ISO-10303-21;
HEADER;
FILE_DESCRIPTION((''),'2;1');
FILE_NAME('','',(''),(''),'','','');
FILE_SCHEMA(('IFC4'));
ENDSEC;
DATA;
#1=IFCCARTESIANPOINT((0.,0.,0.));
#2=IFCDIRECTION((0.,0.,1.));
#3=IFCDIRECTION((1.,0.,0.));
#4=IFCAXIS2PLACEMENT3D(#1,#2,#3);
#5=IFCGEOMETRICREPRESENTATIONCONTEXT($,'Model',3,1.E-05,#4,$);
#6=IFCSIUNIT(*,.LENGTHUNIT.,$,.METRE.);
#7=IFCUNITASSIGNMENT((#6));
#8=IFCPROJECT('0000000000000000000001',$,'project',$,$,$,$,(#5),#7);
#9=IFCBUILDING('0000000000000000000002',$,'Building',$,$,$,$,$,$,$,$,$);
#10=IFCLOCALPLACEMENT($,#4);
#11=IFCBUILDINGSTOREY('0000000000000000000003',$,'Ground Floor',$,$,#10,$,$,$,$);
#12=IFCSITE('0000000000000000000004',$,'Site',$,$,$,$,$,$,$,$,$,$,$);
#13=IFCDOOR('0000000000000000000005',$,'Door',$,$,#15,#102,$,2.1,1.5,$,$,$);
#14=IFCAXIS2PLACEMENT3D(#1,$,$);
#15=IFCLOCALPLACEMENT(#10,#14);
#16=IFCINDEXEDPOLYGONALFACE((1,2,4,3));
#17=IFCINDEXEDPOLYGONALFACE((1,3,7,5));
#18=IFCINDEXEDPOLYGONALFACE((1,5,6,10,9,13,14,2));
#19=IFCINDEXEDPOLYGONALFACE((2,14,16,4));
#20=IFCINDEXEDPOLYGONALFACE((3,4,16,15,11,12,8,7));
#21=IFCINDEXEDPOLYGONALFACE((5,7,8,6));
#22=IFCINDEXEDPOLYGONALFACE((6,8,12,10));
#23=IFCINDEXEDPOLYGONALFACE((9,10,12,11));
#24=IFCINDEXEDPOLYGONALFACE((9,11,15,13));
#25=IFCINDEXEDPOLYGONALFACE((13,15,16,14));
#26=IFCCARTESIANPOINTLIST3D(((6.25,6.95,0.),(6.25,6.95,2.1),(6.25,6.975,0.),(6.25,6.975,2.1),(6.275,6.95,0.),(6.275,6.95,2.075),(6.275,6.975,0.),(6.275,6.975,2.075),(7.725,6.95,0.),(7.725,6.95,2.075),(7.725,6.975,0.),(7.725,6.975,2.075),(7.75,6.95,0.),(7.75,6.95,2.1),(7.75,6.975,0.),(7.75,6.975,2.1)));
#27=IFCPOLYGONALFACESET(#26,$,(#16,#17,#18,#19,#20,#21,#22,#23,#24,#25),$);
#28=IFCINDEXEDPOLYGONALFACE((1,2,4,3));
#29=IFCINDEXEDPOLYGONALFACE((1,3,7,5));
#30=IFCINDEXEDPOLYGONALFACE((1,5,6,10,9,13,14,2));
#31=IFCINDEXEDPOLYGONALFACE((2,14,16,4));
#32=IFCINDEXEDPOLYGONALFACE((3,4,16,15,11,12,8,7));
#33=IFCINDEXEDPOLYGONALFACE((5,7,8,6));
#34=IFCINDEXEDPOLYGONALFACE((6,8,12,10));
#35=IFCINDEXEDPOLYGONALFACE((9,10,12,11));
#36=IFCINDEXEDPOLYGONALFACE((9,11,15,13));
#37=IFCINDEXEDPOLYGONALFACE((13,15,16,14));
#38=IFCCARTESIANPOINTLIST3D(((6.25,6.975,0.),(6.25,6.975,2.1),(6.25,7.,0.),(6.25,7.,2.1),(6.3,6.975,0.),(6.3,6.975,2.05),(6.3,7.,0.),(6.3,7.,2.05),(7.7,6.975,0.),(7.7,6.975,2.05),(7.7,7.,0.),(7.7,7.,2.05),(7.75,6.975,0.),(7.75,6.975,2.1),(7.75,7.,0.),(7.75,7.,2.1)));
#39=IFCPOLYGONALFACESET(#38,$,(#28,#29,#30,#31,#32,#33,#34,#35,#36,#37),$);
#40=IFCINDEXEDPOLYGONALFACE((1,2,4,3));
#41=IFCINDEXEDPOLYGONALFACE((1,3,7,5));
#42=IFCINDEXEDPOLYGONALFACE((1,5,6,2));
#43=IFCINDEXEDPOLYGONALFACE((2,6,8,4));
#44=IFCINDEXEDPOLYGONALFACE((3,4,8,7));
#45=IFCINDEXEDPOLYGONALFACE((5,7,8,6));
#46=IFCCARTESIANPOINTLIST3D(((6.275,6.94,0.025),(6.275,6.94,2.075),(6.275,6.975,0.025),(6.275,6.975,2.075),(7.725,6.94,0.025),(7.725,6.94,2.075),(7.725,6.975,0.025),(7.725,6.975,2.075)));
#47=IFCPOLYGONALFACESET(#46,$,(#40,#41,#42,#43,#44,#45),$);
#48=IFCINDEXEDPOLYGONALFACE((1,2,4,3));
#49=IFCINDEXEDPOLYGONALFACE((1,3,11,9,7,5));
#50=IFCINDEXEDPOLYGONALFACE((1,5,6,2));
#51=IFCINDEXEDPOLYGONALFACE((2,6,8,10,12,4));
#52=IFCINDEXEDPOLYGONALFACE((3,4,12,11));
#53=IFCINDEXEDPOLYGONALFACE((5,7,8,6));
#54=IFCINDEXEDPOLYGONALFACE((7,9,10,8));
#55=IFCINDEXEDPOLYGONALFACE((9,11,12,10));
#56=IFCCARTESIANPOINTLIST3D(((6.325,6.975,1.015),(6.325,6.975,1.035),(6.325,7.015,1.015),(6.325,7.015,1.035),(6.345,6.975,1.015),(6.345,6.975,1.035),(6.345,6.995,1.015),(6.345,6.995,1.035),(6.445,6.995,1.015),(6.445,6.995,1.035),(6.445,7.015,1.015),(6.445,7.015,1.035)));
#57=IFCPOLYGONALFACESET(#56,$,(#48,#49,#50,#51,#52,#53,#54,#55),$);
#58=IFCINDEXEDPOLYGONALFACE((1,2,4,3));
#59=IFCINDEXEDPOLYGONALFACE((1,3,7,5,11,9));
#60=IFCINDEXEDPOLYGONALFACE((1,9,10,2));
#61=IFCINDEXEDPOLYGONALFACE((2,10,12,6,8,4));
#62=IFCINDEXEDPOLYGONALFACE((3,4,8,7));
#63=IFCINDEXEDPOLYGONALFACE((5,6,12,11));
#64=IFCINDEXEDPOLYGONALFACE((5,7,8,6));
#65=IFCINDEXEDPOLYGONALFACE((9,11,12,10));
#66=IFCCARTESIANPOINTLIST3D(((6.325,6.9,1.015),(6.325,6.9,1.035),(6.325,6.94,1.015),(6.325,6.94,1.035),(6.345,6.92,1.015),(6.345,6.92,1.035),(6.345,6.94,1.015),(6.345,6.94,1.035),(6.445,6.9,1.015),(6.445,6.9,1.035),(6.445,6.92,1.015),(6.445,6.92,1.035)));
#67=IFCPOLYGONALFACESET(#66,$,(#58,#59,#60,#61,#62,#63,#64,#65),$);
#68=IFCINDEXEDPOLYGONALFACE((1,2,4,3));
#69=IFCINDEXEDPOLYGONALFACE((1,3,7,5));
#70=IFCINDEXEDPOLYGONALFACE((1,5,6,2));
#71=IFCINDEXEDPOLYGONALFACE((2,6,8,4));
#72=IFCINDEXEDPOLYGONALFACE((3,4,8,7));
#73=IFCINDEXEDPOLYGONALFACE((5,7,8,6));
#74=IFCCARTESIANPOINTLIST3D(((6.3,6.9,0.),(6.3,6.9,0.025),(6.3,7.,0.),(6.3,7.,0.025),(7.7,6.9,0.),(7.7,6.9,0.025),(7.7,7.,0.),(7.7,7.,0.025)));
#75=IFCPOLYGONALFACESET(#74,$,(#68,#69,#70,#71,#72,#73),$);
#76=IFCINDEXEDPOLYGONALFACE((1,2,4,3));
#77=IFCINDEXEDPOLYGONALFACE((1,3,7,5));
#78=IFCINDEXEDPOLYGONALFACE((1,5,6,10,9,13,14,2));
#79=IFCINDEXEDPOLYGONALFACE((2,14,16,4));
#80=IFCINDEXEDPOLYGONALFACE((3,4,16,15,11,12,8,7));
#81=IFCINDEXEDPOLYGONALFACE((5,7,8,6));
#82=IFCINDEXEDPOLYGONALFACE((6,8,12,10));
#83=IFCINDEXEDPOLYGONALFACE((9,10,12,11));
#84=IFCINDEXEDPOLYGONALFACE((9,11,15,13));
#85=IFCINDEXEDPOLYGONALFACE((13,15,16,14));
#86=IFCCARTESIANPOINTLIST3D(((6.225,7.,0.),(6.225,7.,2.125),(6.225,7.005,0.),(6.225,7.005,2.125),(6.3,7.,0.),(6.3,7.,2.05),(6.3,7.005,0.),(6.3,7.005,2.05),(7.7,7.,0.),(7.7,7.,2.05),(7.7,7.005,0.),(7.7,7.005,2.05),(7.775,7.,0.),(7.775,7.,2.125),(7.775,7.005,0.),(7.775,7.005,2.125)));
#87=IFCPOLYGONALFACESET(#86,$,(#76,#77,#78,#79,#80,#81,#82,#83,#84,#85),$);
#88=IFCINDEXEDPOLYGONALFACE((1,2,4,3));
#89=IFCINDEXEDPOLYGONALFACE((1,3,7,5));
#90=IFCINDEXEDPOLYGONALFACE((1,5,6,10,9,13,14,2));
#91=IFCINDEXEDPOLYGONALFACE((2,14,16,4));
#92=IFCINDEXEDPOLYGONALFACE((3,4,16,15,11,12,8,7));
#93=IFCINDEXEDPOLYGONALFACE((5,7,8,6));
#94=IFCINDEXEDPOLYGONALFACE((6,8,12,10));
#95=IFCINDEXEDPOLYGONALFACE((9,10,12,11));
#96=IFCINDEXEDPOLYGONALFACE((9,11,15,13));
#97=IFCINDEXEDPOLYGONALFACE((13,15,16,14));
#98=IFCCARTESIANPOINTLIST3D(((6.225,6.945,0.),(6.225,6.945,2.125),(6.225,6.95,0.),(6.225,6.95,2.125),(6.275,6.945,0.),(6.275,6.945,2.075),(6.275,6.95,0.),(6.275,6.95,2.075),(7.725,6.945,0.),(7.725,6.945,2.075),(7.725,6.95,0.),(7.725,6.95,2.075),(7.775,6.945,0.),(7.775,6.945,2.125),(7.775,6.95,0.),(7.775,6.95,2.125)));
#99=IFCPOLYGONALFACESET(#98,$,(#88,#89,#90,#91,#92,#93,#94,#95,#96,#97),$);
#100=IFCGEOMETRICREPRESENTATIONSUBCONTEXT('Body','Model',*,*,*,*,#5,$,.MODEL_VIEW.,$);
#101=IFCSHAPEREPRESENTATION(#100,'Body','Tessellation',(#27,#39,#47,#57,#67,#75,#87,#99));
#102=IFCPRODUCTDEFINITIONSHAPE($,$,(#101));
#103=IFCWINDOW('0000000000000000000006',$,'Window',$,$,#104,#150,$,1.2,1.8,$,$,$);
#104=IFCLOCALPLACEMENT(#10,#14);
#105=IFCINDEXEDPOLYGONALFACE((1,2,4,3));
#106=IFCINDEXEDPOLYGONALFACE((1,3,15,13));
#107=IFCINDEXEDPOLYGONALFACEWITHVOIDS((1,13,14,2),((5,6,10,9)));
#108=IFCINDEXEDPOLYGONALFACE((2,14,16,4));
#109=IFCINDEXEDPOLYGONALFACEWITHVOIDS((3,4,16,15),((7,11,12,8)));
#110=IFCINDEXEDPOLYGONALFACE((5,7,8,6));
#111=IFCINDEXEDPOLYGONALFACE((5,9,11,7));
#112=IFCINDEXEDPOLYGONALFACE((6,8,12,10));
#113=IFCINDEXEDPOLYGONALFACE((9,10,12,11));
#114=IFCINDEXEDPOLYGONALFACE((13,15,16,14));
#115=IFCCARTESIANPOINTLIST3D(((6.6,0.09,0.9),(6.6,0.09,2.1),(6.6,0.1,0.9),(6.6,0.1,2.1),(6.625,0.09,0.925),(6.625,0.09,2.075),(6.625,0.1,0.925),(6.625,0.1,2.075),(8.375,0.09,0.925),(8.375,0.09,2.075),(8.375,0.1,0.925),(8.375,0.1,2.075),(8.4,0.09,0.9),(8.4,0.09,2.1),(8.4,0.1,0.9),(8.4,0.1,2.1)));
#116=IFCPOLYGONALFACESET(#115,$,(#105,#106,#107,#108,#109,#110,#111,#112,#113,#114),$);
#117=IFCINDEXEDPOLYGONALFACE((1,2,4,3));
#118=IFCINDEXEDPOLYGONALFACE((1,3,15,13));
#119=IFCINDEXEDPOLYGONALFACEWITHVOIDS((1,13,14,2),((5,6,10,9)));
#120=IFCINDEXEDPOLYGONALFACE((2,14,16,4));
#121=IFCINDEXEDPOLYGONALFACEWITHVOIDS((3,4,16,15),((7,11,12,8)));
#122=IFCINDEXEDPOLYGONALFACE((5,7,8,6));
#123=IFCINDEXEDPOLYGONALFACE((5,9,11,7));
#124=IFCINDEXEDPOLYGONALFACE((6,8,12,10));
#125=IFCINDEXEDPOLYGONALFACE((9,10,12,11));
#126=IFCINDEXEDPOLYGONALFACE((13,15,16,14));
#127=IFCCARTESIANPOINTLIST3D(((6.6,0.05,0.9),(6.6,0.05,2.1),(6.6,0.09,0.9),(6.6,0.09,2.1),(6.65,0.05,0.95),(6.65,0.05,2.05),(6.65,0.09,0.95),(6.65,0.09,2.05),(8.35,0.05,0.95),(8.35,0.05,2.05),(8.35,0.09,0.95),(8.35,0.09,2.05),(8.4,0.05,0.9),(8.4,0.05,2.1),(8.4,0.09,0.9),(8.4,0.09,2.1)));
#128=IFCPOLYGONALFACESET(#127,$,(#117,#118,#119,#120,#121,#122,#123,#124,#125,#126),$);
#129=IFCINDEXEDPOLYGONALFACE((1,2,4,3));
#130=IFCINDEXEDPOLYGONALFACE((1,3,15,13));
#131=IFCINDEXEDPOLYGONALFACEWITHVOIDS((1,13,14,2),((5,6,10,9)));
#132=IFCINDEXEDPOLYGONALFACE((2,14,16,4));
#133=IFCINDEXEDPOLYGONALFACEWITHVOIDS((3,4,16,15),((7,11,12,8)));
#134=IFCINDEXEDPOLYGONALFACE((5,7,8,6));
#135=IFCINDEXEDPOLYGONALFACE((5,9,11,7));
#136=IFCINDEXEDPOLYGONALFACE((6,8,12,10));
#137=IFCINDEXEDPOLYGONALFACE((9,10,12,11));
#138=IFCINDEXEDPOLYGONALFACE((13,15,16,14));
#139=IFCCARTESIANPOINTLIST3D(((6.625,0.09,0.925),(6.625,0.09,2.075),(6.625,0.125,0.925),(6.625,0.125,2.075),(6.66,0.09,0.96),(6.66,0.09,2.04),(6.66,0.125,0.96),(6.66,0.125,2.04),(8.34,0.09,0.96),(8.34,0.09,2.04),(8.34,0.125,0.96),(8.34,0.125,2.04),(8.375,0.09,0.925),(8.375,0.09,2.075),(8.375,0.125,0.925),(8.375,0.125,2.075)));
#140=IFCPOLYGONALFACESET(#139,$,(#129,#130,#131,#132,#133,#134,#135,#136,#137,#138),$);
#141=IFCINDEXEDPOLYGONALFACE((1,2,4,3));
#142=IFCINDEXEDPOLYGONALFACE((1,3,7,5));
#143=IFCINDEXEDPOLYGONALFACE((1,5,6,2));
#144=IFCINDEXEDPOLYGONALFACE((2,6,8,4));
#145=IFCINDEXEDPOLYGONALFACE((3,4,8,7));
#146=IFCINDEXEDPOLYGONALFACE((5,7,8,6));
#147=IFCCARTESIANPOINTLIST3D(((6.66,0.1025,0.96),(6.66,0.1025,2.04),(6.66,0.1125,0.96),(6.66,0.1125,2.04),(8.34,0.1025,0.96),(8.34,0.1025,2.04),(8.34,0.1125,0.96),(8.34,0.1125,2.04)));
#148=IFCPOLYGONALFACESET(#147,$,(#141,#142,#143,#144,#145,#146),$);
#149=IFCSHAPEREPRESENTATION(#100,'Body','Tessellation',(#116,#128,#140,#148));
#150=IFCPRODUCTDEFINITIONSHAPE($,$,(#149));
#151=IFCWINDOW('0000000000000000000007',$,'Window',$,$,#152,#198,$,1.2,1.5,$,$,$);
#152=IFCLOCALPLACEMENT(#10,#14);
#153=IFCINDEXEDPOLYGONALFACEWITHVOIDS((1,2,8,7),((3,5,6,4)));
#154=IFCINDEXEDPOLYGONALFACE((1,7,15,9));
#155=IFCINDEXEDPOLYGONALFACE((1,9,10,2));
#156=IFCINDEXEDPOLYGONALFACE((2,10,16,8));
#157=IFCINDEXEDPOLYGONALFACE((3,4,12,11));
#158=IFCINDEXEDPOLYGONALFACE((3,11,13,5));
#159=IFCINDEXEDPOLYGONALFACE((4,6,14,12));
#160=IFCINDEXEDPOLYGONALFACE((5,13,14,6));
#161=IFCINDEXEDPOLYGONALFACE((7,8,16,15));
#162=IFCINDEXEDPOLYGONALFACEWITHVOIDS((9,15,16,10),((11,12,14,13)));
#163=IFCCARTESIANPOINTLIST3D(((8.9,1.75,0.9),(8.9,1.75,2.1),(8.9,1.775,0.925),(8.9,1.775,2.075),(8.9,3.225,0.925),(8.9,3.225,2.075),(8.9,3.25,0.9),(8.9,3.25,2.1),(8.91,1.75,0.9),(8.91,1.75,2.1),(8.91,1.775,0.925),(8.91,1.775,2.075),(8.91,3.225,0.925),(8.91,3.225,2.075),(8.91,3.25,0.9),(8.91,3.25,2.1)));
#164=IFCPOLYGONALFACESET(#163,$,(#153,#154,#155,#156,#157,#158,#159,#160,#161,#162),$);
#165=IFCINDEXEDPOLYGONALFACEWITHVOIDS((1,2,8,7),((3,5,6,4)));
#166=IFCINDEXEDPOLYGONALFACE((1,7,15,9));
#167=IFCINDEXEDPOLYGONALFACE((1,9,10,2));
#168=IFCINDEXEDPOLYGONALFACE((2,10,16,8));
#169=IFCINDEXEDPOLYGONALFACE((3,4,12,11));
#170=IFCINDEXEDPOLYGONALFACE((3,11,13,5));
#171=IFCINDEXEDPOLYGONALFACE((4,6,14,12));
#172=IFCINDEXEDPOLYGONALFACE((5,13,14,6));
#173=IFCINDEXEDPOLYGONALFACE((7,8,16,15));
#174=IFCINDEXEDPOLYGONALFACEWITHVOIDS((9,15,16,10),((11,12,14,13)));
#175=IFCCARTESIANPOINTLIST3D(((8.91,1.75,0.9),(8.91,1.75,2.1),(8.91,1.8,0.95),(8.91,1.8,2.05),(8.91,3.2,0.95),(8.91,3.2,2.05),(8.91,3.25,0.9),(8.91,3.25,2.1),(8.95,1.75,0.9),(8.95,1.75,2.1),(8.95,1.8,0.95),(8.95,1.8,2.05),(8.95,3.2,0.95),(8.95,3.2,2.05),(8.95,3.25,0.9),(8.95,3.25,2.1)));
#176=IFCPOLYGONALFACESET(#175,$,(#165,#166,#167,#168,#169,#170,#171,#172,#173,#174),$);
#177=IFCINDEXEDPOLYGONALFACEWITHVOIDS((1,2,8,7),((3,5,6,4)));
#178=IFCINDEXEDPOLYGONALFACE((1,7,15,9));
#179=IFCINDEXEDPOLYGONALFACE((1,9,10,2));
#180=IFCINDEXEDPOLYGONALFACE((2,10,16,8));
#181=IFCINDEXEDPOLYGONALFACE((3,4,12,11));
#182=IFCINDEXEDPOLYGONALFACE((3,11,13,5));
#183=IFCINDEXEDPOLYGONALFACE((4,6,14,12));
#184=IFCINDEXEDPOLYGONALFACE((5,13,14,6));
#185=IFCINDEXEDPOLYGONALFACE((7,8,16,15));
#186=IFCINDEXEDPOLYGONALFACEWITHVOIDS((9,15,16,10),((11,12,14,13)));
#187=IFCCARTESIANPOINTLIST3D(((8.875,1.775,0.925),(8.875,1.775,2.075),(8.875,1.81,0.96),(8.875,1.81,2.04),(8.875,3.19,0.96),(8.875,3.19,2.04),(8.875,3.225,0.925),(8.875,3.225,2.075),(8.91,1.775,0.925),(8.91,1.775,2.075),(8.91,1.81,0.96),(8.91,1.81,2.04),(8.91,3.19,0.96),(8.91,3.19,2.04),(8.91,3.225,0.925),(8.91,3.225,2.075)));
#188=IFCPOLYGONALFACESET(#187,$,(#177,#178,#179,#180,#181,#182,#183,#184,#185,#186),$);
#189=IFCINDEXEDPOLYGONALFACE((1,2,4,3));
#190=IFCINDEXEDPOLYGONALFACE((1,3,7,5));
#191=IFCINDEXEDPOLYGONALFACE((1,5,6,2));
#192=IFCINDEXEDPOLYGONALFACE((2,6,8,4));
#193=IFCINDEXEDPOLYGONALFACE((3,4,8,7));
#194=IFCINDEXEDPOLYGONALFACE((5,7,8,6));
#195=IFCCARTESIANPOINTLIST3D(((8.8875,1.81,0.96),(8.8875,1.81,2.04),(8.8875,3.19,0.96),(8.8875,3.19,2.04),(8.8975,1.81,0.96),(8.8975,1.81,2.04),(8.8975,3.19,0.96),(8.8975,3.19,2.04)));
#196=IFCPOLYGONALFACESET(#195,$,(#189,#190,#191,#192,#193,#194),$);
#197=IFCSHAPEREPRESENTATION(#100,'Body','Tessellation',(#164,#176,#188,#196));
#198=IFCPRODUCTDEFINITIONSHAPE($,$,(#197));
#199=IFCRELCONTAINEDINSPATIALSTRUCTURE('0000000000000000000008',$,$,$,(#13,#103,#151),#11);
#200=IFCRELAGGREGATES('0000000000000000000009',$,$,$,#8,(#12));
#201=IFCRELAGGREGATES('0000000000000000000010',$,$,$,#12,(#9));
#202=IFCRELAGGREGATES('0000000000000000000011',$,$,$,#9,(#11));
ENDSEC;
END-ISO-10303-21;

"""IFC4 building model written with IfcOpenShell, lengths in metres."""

from ifc_helpers import new_model, si_unit, frame, origin_with_axes, place, context, subcontext, project, spatial, line, indexed_curve, outline, extrude, element, save


model = new_model("IFC4")

# Units and contexts
model_context = context("Model", 3, precision=1e-05, world=origin_with_axes())
body_context = subcontext(model_context, "Body", "Model", "MODEL_VIEW")
ifc_project = project(units=[si_unit("LENGTHUNIT", "METRE")], contexts=[model_context])

# Site, building, storey
site = spatial("IfcSite", under=ifc_project, Name="Site")
building = spatial("IfcBuilding", under=site, Name="Building")
storey_placement = place(None, origin_with_axes())
storey = spatial("IfcBuildingStorey", under=building, at=storey_placement, Name="Ground Floor")

# Door
door_1_placement = place(storey_placement, frame((7.75, 7.0, 0.0), z_axis=(0.0, 0.0, 1.0), x_axis=(-1.0, 0.0, 0.0)))
element("IfcDoor", 1, at=door_1_placement, inside=storey, Name="Door", OverallHeight=2.1, OverallWidth=1.5, context=body_context, shape_type="SweptSolid", body=[
    extrude(outline(indexed_curve([(0.0, 0.0), (0.0, 2.1), (1.5, 2.1), (1.5, 0.0), (1.475, 0.0), (1.475, 2.075), (0.025, 2.075), (0.025, 0.0)], segments=[line(1, 2, 3, 4, 5, 6, 7, 8, 1)])), frame((0.0, 0.025, 0.0), z_axis=(0.0, -1.0, 0.0), x_axis=(1.0, 0.0, 0.0)), (0.0, 0.0, -1.0), 0.025),
    extrude(outline(indexed_curve([(0.0, 0.0), (0.0, 2.1), (1.5, 2.1), (1.5, 0.0), (1.45, 0.0), (1.45, 2.05), (0.05, 2.05), (0.05, 0.0)], segments=[line(1, 2, 3, 4, 5, 6, 7, 8, 1)])), frame((0.0, 0.0, 0.0), z_axis=(0.0, -1.0, 0.0), x_axis=(1.0, 0.0, 0.0)), (0.0, 0.0, -1.0), 0.025),
    extrude(outline(indexed_curve([(0.0, 0.0), (1.45, 0.0), (1.45, 0.035), (0.0, 0.035)], segments=[line(1, 2, 3, 4, 1)])), frame((0.025, 0.025, 0.025), z_axis=(0.0, 0.0, 1.0), x_axis=(1.0, 0.0, 0.0)), (0.0, 0.0, 1.0), 2.05),
    extrude(outline(indexed_curve([(0.0, 0.0), (0.0, -0.04), (-0.12, -0.04), (-0.12, -0.02), (-0.02, -0.02), (-0.02, 0.0)], segments=[line(1, 2, 3, 4, 5, 6, 1)])), frame((1.425, 0.025, 1.015), z_axis=(0.0, 0.0, 1.0), x_axis=(1.0, 0.0, 0.0)), (0.0, 0.0, 1.0), 0.02),
    extrude(outline(indexed_curve([(0.0, 0.0), (0.0, 0.04), (-0.12, 0.04), (-0.12, 0.02), (-0.02, 0.02), (-0.02, 0.0)], segments=[line(1, 2, 3, 4, 5, 6, 1)])), frame((1.425, 0.06, 1.015), z_axis=(0.0, 0.0, 1.0), x_axis=(1.0, 0.0, 0.0)), (0.0, 0.0, 1.0), 0.02),
    extrude(outline(indexed_curve([(0.0, 0.0), (1.4, 0.0), (1.4, 0.1), (0.0, 0.1)], segments=[line(1, 2, 3, 4, 1)])), frame((0.05, 0.0, 0.0), z_axis=(0.0, 0.0, 1.0), x_axis=(1.0, 0.0, 0.0)), (0.0, 0.0, 1.0), 0.025),
    extrude(outline(indexed_curve([(0.0, 0.0), (0.0, 2.125), (1.55, 2.125), (1.55, 0.0), (1.475, 0.0), (1.475, 2.05), (0.075, 2.05), (0.075, 0.0)], segments=[line(1, 2, 3, 4, 5, 6, 7, 8, 1)])), frame((-0.025, -0.005, 0.0), z_axis=(0.0, -1.0, 0.0), x_axis=(1.0, 0.0, 0.0)), (0.0, 0.0, -1.0), 0.005),
    extrude(outline(indexed_curve([(0.0, 0.0), (0.0, 2.125), (1.55, 2.125), (1.55, 0.0), (1.5, 0.0), (1.5, 2.075), (0.05, 2.075), (0.05, 0.0)], segments=[line(1, 2, 3, 4, 5, 6, 7, 8, 1)])), frame((-0.025, 0.05, 0.0), z_axis=(0.0, -1.0, 0.0), x_axis=(1.0, 0.0, 0.0)), (0.0, 0.0, -1.0), 0.005),
])

# Windows
window_1_placement = place(storey_placement, frame((6.6, 0.0, 0.9), z_axis=(0.0, 0.0, 1.0), x_axis=(1.0, 0.0, 0.0)))
element("IfcWindow", 2, at=window_1_placement, inside=storey, Name="Window", OverallHeight=1.2, OverallWidth=1.8, context=body_context, shape_type="SweptSolid", body=[
    extrude(outline(indexed_curve([(0.0, 0.0), (1.8, 0.0), (1.8, 1.2), (0.0, 1.2)], segments=[line(1, 2, 3, 4, 1)]), holes=[indexed_curve([(0.025, 0.025), (1.775, 0.025), (1.775, 1.175), (0.025, 1.175)], segments=[line(1, 2, 3, 4, 1)])]), frame((0.0, 0.09, 0.0), z_axis=(0.0, -1.0, 0.0), x_axis=(1.0, 0.0, 0.0)), (0.0, 0.0, -1.0), 0.01),
    extrude(outline(indexed_curve([(0.0, 0.0), (1.8, 0.0), (1.8, 1.2), (0.0, 1.2)], segments=[line(1, 2, 3, 4, 1)]), holes=[indexed_curve([(0.05, 0.05), (1.75, 0.05), (1.75, 1.15), (0.05, 1.15)], segments=[line(1, 2, 3, 4, 1)])]), frame((0.0, 0.05, 0.0), z_axis=(0.0, -1.0, 0.0), x_axis=(1.0, 0.0, 0.0)), (0.0, 0.0, -1.0), 0.04),
    extrude(outline(indexed_curve([(0.0, 0.0), (1.75, 0.0), (1.75, 1.15), (0.0, 1.15)], segments=[line(1, 2, 3, 4, 1)]), holes=[indexed_curve([(0.035, 0.035), (1.715, 0.035), (1.715, 1.115), (0.035, 1.115)], segments=[line(1, 2, 3, 4, 1)])]), frame((0.025, 0.09, 0.025), z_axis=(0.0, -1.0, 0.0), x_axis=(1.0, 0.0, 0.0)), (0.0, 0.0, -1.0), 0.035),
    extrude(outline(indexed_curve([(0.035, 0.035), (1.715, 0.035), (1.715, 1.115), (0.035, 1.115)], segments=[line(1, 2, 3, 4, 1)])), frame((0.025, 0.1025, 0.025), z_axis=(0.0, -1.0, 0.0), x_axis=(1.0, 0.0, 0.0)), (0.0, 0.0, -1.0), 0.01),
])
window_2_placement = place(storey_placement, frame((9.0, 1.75, 0.9), z_axis=(0.0, 0.0, 1.0), x_axis=(0.0, 1.0, 0.0)))
element("IfcWindow", 3, at=window_2_placement, inside=storey, Name="Window", OverallHeight=1.2, OverallWidth=1.5, context=body_context, shape_type="SweptSolid", body=[
    extrude(outline(indexed_curve([(0.0, 0.0), (1.5, 0.0), (1.5, 1.2), (0.0, 1.2)], segments=[line(1, 2, 3, 4, 1)]), holes=[indexed_curve([(0.025, 0.025), (1.475, 0.025), (1.475, 1.175), (0.025, 1.175)], segments=[line(1, 2, 3, 4, 1)])]), frame((0.0, 0.09, 0.0), z_axis=(0.0, -1.0, 0.0), x_axis=(1.0, 0.0, 0.0)), (0.0, 0.0, -1.0), 0.01),
    extrude(outline(indexed_curve([(0.0, 0.0), (1.5, 0.0), (1.5, 1.2), (0.0, 1.2)], segments=[line(1, 2, 3, 4, 1)]), holes=[indexed_curve([(0.05, 0.05), (1.45, 0.05), (1.45, 1.15), (0.05, 1.15)], segments=[line(1, 2, 3, 4, 1)])]), frame((0.0, 0.05, 0.0), z_axis=(0.0, -1.0, 0.0), x_axis=(1.0, 0.0, 0.0)), (0.0, 0.0, -1.0), 0.04),
    extrude(outline(indexed_curve([(0.0, 0.0), (1.45, 0.0), (1.45, 1.15), (0.0, 1.15)], segments=[line(1, 2, 3, 4, 1)]), holes=[indexed_curve([(0.035, 0.035), (1.415, 0.035), (1.415, 1.115), (0.035, 1.115)], segments=[line(1, 2, 3, 4, 1)])]), frame((0.025, 0.09, 0.025), z_axis=(0.0, -1.0, 0.0), x_axis=(1.0, 0.0, 0.0)), (0.0, 0.0, -1.0), 0.035),
    extrude(outline(indexed_curve([(0.035, 0.035), (1.415, 0.035), (1.415, 1.115), (0.035, 1.115)], segments=[line(1, 2, 3, 4, 1)])), frame((0.025, 0.1025, 0.025), z_axis=(0.0, -1.0, 0.0), x_axis=(1.0, 0.0, 0.0)), (0.0, 0.0, -1.0), 0.01),
])

save(model, "model.ifc")
